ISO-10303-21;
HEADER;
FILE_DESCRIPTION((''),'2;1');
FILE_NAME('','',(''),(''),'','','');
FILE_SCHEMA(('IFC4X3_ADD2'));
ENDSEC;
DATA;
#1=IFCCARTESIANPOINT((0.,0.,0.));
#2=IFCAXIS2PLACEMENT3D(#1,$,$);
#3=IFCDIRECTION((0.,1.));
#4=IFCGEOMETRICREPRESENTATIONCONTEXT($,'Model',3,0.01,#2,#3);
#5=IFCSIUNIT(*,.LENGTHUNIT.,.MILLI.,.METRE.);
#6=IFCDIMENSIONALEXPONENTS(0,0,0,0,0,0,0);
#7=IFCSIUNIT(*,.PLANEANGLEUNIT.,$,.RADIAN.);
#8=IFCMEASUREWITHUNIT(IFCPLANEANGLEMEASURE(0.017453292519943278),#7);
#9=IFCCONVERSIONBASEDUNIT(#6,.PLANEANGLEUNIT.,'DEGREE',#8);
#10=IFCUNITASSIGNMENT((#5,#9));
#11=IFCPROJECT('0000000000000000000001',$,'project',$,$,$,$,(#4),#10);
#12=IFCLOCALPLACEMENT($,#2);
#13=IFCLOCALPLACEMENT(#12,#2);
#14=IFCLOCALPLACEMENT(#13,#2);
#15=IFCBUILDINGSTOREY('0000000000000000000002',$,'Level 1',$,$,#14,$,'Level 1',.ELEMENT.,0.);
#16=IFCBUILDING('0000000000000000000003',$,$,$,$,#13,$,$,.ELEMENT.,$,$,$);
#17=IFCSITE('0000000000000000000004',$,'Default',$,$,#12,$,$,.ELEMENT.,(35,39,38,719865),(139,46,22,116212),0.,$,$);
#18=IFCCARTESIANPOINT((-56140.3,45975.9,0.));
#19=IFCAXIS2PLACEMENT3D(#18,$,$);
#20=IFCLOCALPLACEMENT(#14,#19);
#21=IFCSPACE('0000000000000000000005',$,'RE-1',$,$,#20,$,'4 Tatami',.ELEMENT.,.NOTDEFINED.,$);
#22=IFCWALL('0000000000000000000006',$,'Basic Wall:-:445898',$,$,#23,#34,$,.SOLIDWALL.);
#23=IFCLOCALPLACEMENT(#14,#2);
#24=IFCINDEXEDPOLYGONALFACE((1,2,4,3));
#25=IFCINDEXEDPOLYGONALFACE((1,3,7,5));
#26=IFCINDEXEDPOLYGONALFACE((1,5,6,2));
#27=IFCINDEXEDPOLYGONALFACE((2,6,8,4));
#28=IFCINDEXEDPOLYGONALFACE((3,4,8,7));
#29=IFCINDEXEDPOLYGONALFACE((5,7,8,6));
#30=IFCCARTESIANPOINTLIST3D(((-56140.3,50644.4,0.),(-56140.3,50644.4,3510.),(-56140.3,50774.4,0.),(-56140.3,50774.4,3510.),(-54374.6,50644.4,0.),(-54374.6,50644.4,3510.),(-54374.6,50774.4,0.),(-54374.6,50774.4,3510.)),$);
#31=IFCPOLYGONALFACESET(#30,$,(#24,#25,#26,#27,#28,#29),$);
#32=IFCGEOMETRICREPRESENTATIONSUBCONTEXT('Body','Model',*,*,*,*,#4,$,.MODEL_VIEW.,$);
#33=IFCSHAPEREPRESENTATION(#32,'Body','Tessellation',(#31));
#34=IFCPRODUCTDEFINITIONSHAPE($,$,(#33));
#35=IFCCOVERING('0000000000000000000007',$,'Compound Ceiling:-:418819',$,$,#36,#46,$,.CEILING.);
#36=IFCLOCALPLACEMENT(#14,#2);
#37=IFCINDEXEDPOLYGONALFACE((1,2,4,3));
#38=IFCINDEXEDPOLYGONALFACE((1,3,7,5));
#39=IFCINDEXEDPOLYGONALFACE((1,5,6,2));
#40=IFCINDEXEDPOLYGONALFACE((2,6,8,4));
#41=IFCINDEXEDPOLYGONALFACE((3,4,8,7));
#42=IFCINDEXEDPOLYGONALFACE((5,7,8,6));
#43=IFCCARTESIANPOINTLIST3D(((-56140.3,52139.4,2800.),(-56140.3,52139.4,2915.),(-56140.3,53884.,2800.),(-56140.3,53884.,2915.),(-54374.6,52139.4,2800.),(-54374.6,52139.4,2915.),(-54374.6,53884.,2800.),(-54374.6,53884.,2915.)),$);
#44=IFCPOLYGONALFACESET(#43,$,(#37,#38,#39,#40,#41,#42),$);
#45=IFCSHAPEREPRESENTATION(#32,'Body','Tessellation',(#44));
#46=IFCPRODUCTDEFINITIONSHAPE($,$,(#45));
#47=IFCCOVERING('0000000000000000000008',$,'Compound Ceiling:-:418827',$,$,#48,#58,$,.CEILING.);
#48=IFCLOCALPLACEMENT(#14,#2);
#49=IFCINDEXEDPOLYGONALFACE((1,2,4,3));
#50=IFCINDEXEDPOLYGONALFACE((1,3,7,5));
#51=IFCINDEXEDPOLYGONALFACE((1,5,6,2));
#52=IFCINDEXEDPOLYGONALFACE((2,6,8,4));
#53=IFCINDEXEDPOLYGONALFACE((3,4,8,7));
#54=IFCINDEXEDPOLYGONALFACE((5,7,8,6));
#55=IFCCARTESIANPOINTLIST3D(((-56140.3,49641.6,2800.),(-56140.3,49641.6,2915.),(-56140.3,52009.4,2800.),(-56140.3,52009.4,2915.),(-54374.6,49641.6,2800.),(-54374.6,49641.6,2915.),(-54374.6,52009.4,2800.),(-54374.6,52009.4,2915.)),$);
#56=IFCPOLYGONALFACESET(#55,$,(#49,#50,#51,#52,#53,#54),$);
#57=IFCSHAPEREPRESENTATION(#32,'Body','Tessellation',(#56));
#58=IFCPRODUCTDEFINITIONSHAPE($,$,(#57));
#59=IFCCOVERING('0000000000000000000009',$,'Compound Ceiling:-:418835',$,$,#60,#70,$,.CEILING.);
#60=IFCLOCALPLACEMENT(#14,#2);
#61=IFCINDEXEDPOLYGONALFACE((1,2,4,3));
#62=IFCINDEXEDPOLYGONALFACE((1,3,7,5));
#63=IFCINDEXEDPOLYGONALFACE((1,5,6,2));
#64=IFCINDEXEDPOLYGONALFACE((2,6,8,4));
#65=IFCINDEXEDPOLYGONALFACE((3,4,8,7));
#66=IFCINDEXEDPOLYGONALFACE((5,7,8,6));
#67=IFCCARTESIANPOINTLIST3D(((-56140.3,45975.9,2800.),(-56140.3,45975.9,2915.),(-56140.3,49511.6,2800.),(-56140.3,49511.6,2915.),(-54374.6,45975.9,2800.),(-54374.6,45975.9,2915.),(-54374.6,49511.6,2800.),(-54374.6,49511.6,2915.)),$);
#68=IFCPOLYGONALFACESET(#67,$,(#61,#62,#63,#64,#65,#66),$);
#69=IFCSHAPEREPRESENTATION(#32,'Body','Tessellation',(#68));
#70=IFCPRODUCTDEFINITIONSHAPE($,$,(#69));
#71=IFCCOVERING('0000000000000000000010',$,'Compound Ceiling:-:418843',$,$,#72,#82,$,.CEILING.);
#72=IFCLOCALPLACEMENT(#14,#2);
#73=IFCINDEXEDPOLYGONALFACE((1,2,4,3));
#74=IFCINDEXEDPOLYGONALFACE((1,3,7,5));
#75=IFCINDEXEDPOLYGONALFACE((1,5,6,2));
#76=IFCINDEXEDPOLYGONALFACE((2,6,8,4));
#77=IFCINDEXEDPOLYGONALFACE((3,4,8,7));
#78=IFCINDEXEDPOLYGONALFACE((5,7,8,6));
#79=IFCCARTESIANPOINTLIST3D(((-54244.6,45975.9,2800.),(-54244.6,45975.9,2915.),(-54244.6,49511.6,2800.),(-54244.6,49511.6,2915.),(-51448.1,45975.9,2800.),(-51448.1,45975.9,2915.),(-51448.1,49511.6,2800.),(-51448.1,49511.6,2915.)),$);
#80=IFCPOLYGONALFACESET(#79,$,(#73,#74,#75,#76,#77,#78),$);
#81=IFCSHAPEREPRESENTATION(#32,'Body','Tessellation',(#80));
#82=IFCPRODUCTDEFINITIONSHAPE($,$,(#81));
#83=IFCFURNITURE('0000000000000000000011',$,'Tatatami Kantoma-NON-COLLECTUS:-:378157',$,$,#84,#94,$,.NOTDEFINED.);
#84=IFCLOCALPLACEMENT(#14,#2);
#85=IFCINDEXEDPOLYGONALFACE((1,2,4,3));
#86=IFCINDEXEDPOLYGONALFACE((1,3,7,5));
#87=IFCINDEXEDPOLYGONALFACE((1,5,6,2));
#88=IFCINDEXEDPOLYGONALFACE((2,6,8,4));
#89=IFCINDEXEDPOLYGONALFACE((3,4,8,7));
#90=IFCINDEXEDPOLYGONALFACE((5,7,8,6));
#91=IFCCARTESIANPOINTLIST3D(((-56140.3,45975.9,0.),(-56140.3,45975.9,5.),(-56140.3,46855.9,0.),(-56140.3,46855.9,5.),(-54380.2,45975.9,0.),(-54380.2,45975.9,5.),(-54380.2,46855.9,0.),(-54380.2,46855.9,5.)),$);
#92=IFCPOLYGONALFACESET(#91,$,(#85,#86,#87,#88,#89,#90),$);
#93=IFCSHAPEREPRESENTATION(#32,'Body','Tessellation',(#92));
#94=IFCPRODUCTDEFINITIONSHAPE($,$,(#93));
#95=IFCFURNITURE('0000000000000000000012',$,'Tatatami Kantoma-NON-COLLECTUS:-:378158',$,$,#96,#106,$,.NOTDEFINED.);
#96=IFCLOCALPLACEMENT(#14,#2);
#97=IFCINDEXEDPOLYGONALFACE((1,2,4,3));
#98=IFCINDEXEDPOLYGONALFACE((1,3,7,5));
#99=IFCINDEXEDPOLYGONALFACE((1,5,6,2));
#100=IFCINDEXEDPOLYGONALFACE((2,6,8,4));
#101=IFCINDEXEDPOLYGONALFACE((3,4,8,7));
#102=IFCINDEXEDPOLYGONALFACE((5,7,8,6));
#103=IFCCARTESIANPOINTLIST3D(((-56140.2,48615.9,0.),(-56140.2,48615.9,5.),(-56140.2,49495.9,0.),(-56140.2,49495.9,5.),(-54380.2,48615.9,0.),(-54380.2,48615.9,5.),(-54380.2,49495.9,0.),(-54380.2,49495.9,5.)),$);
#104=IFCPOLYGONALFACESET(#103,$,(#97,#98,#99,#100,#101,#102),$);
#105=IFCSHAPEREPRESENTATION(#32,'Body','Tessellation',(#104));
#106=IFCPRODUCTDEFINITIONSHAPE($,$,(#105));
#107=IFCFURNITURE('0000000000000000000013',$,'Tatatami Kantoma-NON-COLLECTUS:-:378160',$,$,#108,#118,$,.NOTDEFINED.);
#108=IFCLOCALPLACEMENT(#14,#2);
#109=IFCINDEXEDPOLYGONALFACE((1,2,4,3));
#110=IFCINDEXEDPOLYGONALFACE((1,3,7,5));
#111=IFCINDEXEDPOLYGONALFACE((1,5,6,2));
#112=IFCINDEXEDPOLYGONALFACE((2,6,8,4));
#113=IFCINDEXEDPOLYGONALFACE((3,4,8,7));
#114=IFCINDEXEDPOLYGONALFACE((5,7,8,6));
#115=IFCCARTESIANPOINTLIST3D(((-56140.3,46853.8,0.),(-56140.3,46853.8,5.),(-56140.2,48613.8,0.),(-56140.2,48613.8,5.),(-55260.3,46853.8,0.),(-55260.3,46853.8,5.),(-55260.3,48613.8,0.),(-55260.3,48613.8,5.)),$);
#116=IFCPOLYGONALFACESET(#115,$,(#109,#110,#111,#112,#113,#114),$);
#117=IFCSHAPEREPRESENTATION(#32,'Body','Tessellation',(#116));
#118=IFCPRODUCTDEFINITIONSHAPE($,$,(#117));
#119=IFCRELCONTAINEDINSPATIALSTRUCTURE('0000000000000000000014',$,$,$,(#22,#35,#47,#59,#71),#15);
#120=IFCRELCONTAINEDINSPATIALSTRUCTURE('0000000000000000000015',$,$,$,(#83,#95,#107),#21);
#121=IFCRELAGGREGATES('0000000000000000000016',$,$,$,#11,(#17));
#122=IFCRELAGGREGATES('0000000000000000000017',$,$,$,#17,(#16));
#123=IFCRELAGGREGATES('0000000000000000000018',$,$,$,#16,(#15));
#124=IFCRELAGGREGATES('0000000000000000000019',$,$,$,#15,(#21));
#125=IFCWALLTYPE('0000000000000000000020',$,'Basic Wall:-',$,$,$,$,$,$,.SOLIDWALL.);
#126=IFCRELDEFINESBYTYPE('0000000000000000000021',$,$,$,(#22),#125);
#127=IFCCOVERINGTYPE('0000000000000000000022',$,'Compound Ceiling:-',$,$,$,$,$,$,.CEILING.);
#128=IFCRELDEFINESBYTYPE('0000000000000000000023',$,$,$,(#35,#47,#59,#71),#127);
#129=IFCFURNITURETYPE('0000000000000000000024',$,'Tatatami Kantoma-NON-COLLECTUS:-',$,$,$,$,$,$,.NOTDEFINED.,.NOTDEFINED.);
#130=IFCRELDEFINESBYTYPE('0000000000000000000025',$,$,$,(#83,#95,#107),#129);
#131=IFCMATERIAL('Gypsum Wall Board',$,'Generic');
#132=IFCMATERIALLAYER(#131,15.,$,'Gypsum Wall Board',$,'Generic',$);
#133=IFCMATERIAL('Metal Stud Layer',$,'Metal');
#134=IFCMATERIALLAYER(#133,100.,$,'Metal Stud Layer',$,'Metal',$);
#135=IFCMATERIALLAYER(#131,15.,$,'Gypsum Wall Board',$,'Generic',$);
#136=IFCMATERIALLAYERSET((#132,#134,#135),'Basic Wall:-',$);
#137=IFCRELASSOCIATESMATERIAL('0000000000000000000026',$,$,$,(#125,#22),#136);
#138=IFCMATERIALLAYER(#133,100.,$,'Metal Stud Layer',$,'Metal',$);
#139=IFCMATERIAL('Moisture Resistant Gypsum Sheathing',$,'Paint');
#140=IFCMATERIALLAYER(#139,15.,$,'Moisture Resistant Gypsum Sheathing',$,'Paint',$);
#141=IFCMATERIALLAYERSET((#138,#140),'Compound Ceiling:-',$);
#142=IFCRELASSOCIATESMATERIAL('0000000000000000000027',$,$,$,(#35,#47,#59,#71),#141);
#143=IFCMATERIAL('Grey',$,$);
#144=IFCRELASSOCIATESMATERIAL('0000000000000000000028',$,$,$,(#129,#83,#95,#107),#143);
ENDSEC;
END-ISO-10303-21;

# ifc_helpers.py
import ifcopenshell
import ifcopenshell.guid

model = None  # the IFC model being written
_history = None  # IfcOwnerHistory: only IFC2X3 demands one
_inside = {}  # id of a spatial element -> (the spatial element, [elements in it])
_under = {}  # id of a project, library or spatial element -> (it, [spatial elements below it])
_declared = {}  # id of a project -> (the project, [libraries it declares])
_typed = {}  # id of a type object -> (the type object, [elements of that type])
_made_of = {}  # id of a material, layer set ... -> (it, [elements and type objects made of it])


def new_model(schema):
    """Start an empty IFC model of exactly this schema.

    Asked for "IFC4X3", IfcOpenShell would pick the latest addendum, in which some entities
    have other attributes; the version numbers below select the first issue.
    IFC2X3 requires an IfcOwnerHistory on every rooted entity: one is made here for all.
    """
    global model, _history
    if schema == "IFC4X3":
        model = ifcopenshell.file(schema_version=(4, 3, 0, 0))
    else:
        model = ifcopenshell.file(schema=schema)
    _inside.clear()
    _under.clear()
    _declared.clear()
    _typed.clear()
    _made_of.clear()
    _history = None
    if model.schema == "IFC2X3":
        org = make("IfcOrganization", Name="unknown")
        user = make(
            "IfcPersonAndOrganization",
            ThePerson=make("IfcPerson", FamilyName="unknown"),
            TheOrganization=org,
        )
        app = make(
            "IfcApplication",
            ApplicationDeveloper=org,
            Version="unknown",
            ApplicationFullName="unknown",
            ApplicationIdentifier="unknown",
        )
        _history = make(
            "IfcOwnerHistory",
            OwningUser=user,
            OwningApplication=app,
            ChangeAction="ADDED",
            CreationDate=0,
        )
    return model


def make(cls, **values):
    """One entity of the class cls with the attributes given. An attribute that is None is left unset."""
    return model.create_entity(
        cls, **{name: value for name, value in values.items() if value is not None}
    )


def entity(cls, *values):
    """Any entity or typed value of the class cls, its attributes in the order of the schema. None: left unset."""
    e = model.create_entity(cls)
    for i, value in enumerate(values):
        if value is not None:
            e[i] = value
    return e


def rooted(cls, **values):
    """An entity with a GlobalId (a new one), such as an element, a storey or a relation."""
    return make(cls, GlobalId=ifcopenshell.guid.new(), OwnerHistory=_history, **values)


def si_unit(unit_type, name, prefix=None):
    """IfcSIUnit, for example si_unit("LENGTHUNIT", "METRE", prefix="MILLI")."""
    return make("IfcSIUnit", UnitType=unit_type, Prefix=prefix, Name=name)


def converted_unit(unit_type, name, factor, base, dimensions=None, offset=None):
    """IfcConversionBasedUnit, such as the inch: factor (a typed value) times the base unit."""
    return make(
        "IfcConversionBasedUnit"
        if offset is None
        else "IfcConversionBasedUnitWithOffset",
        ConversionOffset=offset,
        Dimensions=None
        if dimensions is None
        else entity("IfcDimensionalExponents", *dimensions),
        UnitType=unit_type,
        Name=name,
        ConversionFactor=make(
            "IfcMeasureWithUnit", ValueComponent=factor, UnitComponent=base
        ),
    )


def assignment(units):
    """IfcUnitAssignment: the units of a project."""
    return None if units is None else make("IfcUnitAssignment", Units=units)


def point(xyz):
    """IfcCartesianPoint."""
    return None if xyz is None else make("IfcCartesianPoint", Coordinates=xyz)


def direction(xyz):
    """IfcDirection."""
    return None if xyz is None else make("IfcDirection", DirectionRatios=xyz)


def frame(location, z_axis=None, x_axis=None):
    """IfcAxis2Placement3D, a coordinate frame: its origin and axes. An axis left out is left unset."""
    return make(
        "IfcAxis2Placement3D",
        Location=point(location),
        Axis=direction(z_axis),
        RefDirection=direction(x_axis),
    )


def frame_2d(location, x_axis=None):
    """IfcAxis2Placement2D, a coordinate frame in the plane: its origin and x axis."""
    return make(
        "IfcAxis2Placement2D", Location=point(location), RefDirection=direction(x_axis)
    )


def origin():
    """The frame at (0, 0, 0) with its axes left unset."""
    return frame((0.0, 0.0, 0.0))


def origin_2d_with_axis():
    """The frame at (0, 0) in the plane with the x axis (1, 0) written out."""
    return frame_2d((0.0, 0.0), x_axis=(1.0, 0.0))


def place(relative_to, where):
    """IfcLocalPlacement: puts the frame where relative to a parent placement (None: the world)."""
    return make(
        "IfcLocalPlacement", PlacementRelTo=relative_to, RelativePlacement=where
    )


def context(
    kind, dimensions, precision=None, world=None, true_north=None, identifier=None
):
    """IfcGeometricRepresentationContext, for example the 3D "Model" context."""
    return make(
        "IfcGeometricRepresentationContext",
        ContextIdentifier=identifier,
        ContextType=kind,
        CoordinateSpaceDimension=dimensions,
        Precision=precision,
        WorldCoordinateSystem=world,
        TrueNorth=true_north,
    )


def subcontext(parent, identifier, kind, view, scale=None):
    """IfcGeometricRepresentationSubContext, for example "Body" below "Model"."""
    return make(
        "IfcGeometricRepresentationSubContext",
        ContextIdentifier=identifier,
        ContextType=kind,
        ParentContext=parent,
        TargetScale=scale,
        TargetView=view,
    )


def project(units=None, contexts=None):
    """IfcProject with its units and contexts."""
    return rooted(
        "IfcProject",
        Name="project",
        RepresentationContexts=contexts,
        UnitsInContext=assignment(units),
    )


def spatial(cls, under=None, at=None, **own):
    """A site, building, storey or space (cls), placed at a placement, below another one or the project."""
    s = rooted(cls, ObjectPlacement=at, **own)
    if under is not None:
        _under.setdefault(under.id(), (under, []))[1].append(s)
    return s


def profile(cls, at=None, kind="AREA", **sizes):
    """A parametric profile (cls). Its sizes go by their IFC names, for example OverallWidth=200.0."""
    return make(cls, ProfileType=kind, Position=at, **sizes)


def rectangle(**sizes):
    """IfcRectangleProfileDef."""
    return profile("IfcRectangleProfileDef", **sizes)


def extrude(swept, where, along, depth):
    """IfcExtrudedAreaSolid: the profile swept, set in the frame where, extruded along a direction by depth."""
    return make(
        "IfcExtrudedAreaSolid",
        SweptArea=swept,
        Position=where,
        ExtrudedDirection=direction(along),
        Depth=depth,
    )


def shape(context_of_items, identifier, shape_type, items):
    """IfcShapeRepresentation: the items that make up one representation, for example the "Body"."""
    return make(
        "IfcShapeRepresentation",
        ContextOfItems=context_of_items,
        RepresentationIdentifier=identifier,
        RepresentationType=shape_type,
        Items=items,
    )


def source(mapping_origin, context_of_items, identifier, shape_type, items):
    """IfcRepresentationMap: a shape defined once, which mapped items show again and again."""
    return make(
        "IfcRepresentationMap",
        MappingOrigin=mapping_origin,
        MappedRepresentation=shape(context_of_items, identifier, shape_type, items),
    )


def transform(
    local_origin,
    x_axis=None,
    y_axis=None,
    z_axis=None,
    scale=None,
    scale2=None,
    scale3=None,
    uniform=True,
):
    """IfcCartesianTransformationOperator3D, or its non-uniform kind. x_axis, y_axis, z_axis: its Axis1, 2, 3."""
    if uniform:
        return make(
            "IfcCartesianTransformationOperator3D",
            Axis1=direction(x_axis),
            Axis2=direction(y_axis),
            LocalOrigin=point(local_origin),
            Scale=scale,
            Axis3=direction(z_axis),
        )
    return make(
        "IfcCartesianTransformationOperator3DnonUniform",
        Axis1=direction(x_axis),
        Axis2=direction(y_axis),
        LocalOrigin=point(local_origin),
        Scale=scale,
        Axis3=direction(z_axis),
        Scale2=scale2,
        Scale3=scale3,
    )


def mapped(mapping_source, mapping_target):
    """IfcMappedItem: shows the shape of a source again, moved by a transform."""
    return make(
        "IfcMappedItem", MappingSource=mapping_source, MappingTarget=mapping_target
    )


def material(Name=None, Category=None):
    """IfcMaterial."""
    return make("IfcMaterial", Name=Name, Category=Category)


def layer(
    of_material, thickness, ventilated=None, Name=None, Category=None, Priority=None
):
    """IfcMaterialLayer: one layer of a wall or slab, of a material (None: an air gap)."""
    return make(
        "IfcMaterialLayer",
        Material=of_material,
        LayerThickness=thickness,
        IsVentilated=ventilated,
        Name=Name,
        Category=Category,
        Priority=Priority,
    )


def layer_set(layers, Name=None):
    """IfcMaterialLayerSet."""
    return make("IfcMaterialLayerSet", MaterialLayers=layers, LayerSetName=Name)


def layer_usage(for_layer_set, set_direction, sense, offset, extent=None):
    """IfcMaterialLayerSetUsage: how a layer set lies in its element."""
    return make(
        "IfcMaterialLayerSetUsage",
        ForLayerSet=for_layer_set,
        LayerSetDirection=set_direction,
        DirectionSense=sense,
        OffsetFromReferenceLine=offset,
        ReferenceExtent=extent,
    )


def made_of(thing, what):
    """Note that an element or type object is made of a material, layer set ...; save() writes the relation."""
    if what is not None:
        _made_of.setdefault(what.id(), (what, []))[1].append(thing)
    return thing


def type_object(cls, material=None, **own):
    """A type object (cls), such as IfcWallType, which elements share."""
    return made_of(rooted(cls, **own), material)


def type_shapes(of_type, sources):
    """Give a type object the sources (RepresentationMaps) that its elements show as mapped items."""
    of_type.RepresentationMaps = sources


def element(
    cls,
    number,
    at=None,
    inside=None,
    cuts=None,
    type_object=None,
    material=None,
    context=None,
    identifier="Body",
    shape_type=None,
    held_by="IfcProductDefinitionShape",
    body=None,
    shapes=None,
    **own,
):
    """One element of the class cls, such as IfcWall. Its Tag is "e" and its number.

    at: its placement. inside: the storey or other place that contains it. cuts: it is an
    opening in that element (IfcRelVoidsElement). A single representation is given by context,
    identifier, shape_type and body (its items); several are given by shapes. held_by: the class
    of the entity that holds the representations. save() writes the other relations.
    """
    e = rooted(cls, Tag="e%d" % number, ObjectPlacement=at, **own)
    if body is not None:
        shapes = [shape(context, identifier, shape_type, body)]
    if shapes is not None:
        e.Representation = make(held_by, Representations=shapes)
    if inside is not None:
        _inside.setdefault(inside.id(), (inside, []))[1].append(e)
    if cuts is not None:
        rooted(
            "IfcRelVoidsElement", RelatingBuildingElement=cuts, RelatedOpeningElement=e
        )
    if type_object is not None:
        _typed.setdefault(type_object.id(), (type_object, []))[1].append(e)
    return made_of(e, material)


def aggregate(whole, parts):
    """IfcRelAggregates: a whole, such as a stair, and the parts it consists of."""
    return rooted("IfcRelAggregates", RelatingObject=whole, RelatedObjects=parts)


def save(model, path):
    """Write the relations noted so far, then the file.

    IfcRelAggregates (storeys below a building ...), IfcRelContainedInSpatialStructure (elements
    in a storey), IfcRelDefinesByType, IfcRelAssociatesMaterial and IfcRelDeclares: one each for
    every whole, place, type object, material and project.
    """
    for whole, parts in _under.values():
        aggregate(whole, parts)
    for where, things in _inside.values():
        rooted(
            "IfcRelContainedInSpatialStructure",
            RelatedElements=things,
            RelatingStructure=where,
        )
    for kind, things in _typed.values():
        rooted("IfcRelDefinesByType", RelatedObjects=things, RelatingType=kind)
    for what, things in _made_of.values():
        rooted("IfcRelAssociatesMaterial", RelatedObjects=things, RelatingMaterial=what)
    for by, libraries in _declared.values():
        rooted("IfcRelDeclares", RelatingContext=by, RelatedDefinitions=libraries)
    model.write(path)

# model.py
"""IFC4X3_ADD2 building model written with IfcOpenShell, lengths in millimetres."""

from ifc_helpers import new_model, entity, si_unit, converted_unit, direction, frame, frame_2d, origin, origin_2d_with_axis, place, context, subcontext, project, spatial, rectangle, extrude, source, transform, mapped, material, layer, layer_set, layer_usage, type_object, type_shapes, element, save


model = new_model("IFC4X3_ADD2")

# Units and contexts
model_context = context("Model", 3, precision=0.01, world=origin(), true_north=direction((0.0, 1.0)))
body_context = subcontext(model_context, "Body", "Model", "MODEL_VIEW")
ifc_project = project(units=[si_unit("LENGTHUNIT", "METRE", prefix="MILLI"), converted_unit("PLANEANGLEUNIT", "DEGREE", entity("IfcPlaneAngleMeasure", 0.017453292519943278), si_unit("PLANEANGLEUNIT", "RADIAN"), dimensions=[0, 0, 0, 0, 0, 0, 0])], contexts=[model_context])

# Site, building, storey
site_placement = place(None, origin())
site = spatial("IfcSite", under=ifc_project, at=site_placement, Name="Default", CompositionType="ELEMENT", RefLatitude=(35, 39, 38, 719865), RefLongitude=(139, 46, 22, 116212), RefElevation=0.0)
building_placement = place(site_placement, origin())
building = spatial("IfcBuilding", under=site, at=building_placement, CompositionType="ELEMENT")
storey_placement = place(building_placement, origin())
storey = spatial("IfcBuildingStorey", under=building, at=storey_placement, Name="Level 1", LongName="Level 1", CompositionType="ELEMENT", Elevation=0.0)

# Shared definitions
ifc_material_1 = material(Name="Gypsum Wall Board", Category="Generic")
ifc_layer_1 = layer(ifc_material_1, 15.0, Name="Gypsum Wall Board", Category="Generic")
ifc_material_2 = material(Name="Metal Stud Layer", Category="Metal")
ifc_layer_2 = layer(ifc_material_2, 100.0, Name="Metal Stud Layer", Category="Metal")
ifc_layer_3 = layer(ifc_material_1, 15.0, Name="Gypsum Wall Board", Category="Generic")
ifc_layer_set_1 = layer_set([ifc_layer_1, ifc_layer_2, ifc_layer_3], Name="Basic Wall:-")
wall_type = type_object("IfcWallType", Name="Basic Wall:-", PredefinedType="SOLIDWALL", material=ifc_layer_set_1)

# Wall
wall_1_placement = place(storey_placement, frame((-54374.6, 50709.4, 0.0), z_axis=(0.0, 0.0, 1.0), x_axis=(-1.0, 0.0, 0.0)))
element("IfcWall", 1, at=wall_1_placement, inside=storey, type_object=wall_type, material=ifc_layer_set_1, Name="Basic Wall:-:445898", PredefinedType="SOLIDWALL", context=body_context, shape_type="SweptSolid", body=[
    extrude(rectangle(XDim=1765.7, YDim=130.0, at=frame_2d((882.9, 0.0), x_axis=(-1.0, 0.0))), origin(), (0.0, 0.0, 1.0), 3510.0),
])

# Coverings
ifc_layer_4 = layer(ifc_material_2, 100.0, Name="Metal Stud Layer", Category="Metal")
ifc_material_3 = material(Name="Moisture Resistant Gypsum Sheathing", Category="Paint")
ifc_layer_5 = layer(ifc_material_3, 15.0, Name="Moisture Resistant Gypsum Sheathing", Category="Paint")
ifc_layer_set_2 = layer_set([ifc_layer_4, ifc_layer_5], Name="Compound Ceiling:-")
covering_type = type_object("IfcCoveringType", Name="Compound Ceiling:-", PredefinedType="CEILING")
ifc_layer_usage_1 = layer_usage(ifc_layer_set_2, "AXIS3", "NEGATIVE", 0.0)
covering_1_placement = place(storey_placement, frame((-56140.3, 52139.4, 2800.0)))
element("IfcCovering", 2, at=covering_1_placement, inside=storey, type_object=covering_type, material=ifc_layer_usage_1, Name="Compound Ceiling:-:418819", PredefinedType="CEILING", context=body_context, shape_type="SweptSolid", body=[
    extrude(rectangle(XDim=1744.7, YDim=1765.7, at=frame_2d((0.0, 0.0), x_axis=(1.0, 0.0))), frame((882.9, 872.3, 0.0), z_axis=(0.0, 0.0, 1.0), x_axis=(0.0, 1.0, 0.0)), (0.0, 0.0, 1.0), 115.0),
])
ifc_layer_usage_2 = layer_usage(ifc_layer_set_2, "AXIS3", "NEGATIVE", 0.0)
covering_2_placement = place(storey_placement, frame((-56140.3, 49641.6, 2800.0)))
element("IfcCovering", 3, at=covering_2_placement, inside=storey, type_object=covering_type, material=ifc_layer_usage_2, Name="Compound Ceiling:-:418827", PredefinedType="CEILING", context=body_context, shape_type="SweptSolid", body=[
    extrude(rectangle(XDim=2367.8, YDim=1765.7, at=frame_2d((0.0, 0.0), x_axis=(1.0, 0.0))), frame((882.9, 1183.9, 0.0), z_axis=(0.0, 0.0, 1.0), x_axis=(0.0, 1.0, 0.0)), (0.0, 0.0, 1.0), 115.0),
])
ifc_layer_usage_3 = layer_usage(ifc_layer_set_2, "AXIS3", "NEGATIVE", 0.0)
covering_3_placement = place(storey_placement, frame((-56140.3, 45975.9, 2800.0)))
element("IfcCovering", 4, at=covering_3_placement, inside=storey, type_object=covering_type, material=ifc_layer_usage_3, Name="Compound Ceiling:-:418835", PredefinedType="CEILING", context=body_context, shape_type="SweptSolid", body=[
    extrude(rectangle(XDim=3535.6, YDim=1765.7, at=frame_2d((0.0, 0.0), x_axis=(1.0, 0.0))), frame((882.9, 1767.8, 0.0), z_axis=(0.0, 0.0, 1.0), x_axis=(0.0, -1.0, 0.0)), (0.0, 0.0, 1.0), 115.0),
])
ifc_layer_usage_4 = layer_usage(ifc_layer_set_2, "AXIS3", "NEGATIVE", 0.0)
covering_4_placement = place(storey_placement, frame((-54244.6, 45975.9, 2800.0)))
element("IfcCovering", 5, at=covering_4_placement, inside=storey, type_object=covering_type, material=ifc_layer_usage_4, Name="Compound Ceiling:-:418843", PredefinedType="CEILING", context=body_context, shape_type="SweptSolid", body=[
    extrude(rectangle(XDim=2796.4, YDim=3535.6, at=frame_2d((0.0, 0.0), x_axis=(1.0, 0.0))), frame((1398.2, 1767.8, 0.0)), (0.0, 0.0, 1.0), 115.0),
])

# Shared definitions
space_1_placement = place(storey_placement, frame((-56140.3, 45975.9, 0.0)))
space_1 = spatial("IfcSpace", under=storey, at=space_1_placement, Name="RE-1", LongName="4 Tatami", CompositionType="ELEMENT", PredefinedType="NOTDEFINED")

# Furniture
ifc_material_4 = material(Name="Grey")
furniture_type_1 = type_object("IfcFurnitureType", Name="Tatatami Kantoma-NON-COLLECTUS:-", AssemblyPlace="NOTDEFINED", PredefinedType="NOTDEFINED", material=ifc_material_4)
shared_shape_1 = source(origin(), body_context, "Body", "SweptSolid", [
    extrude(rectangle(XDim=1760.0, YDim=880.0, at=origin_2d_with_axis()), frame((880.0, 440.0, 0.0), z_axis=(0.0, 0.0, 1.0), x_axis=(-1.0, 0.0, 0.0)), (0.0, 0.0, 1.0), 5.0),
])
type_shapes(furniture_type_1, [shared_shape_1])
for number, where, name in (
    (6, (0.0, 0.0, 0.0), "Tatatami Kantoma-NON-COLLECTUS:-:378157"),
    (7, (0.0, 2640.0, 0.0), "Tatatami Kantoma-NON-COLLECTUS:-:378158"),
):
    element("IfcFurniture", number, at=place(space_1_placement, frame(where)), inside=space_1, type_object=furniture_type_1, material=ifc_material_4, Name=name, PredefinedType="NOTDEFINED", context=body_context, shape_type="MappedRepresentation", body=[
        mapped(shared_shape_1, transform((0.0, 0.0, 0.0), scale=1.0)),
    ])
for number, where, z_axis, x_axis, name in (
    (8, (0.0, 2637.9, 0.0), (0.0, 0.0, 1.0), (-0.000004, -1.0, 0.0), "Tatatami Kantoma-NON-COLLECTUS:-:378160"),
):
    element("IfcFurniture", number, at=place(space_1_placement, frame(where, z_axis=z_axis, x_axis=x_axis)), inside=space_1, type_object=furniture_type_1, material=ifc_material_4, Name=name, PredefinedType="NOTDEFINED", context=body_context, shape_type="MappedRepresentation", body=[
        mapped(shared_shape_1, transform((0.0, 0.0, 0.0), scale=1.0)),
    ])

save(model, "model.ifc")
